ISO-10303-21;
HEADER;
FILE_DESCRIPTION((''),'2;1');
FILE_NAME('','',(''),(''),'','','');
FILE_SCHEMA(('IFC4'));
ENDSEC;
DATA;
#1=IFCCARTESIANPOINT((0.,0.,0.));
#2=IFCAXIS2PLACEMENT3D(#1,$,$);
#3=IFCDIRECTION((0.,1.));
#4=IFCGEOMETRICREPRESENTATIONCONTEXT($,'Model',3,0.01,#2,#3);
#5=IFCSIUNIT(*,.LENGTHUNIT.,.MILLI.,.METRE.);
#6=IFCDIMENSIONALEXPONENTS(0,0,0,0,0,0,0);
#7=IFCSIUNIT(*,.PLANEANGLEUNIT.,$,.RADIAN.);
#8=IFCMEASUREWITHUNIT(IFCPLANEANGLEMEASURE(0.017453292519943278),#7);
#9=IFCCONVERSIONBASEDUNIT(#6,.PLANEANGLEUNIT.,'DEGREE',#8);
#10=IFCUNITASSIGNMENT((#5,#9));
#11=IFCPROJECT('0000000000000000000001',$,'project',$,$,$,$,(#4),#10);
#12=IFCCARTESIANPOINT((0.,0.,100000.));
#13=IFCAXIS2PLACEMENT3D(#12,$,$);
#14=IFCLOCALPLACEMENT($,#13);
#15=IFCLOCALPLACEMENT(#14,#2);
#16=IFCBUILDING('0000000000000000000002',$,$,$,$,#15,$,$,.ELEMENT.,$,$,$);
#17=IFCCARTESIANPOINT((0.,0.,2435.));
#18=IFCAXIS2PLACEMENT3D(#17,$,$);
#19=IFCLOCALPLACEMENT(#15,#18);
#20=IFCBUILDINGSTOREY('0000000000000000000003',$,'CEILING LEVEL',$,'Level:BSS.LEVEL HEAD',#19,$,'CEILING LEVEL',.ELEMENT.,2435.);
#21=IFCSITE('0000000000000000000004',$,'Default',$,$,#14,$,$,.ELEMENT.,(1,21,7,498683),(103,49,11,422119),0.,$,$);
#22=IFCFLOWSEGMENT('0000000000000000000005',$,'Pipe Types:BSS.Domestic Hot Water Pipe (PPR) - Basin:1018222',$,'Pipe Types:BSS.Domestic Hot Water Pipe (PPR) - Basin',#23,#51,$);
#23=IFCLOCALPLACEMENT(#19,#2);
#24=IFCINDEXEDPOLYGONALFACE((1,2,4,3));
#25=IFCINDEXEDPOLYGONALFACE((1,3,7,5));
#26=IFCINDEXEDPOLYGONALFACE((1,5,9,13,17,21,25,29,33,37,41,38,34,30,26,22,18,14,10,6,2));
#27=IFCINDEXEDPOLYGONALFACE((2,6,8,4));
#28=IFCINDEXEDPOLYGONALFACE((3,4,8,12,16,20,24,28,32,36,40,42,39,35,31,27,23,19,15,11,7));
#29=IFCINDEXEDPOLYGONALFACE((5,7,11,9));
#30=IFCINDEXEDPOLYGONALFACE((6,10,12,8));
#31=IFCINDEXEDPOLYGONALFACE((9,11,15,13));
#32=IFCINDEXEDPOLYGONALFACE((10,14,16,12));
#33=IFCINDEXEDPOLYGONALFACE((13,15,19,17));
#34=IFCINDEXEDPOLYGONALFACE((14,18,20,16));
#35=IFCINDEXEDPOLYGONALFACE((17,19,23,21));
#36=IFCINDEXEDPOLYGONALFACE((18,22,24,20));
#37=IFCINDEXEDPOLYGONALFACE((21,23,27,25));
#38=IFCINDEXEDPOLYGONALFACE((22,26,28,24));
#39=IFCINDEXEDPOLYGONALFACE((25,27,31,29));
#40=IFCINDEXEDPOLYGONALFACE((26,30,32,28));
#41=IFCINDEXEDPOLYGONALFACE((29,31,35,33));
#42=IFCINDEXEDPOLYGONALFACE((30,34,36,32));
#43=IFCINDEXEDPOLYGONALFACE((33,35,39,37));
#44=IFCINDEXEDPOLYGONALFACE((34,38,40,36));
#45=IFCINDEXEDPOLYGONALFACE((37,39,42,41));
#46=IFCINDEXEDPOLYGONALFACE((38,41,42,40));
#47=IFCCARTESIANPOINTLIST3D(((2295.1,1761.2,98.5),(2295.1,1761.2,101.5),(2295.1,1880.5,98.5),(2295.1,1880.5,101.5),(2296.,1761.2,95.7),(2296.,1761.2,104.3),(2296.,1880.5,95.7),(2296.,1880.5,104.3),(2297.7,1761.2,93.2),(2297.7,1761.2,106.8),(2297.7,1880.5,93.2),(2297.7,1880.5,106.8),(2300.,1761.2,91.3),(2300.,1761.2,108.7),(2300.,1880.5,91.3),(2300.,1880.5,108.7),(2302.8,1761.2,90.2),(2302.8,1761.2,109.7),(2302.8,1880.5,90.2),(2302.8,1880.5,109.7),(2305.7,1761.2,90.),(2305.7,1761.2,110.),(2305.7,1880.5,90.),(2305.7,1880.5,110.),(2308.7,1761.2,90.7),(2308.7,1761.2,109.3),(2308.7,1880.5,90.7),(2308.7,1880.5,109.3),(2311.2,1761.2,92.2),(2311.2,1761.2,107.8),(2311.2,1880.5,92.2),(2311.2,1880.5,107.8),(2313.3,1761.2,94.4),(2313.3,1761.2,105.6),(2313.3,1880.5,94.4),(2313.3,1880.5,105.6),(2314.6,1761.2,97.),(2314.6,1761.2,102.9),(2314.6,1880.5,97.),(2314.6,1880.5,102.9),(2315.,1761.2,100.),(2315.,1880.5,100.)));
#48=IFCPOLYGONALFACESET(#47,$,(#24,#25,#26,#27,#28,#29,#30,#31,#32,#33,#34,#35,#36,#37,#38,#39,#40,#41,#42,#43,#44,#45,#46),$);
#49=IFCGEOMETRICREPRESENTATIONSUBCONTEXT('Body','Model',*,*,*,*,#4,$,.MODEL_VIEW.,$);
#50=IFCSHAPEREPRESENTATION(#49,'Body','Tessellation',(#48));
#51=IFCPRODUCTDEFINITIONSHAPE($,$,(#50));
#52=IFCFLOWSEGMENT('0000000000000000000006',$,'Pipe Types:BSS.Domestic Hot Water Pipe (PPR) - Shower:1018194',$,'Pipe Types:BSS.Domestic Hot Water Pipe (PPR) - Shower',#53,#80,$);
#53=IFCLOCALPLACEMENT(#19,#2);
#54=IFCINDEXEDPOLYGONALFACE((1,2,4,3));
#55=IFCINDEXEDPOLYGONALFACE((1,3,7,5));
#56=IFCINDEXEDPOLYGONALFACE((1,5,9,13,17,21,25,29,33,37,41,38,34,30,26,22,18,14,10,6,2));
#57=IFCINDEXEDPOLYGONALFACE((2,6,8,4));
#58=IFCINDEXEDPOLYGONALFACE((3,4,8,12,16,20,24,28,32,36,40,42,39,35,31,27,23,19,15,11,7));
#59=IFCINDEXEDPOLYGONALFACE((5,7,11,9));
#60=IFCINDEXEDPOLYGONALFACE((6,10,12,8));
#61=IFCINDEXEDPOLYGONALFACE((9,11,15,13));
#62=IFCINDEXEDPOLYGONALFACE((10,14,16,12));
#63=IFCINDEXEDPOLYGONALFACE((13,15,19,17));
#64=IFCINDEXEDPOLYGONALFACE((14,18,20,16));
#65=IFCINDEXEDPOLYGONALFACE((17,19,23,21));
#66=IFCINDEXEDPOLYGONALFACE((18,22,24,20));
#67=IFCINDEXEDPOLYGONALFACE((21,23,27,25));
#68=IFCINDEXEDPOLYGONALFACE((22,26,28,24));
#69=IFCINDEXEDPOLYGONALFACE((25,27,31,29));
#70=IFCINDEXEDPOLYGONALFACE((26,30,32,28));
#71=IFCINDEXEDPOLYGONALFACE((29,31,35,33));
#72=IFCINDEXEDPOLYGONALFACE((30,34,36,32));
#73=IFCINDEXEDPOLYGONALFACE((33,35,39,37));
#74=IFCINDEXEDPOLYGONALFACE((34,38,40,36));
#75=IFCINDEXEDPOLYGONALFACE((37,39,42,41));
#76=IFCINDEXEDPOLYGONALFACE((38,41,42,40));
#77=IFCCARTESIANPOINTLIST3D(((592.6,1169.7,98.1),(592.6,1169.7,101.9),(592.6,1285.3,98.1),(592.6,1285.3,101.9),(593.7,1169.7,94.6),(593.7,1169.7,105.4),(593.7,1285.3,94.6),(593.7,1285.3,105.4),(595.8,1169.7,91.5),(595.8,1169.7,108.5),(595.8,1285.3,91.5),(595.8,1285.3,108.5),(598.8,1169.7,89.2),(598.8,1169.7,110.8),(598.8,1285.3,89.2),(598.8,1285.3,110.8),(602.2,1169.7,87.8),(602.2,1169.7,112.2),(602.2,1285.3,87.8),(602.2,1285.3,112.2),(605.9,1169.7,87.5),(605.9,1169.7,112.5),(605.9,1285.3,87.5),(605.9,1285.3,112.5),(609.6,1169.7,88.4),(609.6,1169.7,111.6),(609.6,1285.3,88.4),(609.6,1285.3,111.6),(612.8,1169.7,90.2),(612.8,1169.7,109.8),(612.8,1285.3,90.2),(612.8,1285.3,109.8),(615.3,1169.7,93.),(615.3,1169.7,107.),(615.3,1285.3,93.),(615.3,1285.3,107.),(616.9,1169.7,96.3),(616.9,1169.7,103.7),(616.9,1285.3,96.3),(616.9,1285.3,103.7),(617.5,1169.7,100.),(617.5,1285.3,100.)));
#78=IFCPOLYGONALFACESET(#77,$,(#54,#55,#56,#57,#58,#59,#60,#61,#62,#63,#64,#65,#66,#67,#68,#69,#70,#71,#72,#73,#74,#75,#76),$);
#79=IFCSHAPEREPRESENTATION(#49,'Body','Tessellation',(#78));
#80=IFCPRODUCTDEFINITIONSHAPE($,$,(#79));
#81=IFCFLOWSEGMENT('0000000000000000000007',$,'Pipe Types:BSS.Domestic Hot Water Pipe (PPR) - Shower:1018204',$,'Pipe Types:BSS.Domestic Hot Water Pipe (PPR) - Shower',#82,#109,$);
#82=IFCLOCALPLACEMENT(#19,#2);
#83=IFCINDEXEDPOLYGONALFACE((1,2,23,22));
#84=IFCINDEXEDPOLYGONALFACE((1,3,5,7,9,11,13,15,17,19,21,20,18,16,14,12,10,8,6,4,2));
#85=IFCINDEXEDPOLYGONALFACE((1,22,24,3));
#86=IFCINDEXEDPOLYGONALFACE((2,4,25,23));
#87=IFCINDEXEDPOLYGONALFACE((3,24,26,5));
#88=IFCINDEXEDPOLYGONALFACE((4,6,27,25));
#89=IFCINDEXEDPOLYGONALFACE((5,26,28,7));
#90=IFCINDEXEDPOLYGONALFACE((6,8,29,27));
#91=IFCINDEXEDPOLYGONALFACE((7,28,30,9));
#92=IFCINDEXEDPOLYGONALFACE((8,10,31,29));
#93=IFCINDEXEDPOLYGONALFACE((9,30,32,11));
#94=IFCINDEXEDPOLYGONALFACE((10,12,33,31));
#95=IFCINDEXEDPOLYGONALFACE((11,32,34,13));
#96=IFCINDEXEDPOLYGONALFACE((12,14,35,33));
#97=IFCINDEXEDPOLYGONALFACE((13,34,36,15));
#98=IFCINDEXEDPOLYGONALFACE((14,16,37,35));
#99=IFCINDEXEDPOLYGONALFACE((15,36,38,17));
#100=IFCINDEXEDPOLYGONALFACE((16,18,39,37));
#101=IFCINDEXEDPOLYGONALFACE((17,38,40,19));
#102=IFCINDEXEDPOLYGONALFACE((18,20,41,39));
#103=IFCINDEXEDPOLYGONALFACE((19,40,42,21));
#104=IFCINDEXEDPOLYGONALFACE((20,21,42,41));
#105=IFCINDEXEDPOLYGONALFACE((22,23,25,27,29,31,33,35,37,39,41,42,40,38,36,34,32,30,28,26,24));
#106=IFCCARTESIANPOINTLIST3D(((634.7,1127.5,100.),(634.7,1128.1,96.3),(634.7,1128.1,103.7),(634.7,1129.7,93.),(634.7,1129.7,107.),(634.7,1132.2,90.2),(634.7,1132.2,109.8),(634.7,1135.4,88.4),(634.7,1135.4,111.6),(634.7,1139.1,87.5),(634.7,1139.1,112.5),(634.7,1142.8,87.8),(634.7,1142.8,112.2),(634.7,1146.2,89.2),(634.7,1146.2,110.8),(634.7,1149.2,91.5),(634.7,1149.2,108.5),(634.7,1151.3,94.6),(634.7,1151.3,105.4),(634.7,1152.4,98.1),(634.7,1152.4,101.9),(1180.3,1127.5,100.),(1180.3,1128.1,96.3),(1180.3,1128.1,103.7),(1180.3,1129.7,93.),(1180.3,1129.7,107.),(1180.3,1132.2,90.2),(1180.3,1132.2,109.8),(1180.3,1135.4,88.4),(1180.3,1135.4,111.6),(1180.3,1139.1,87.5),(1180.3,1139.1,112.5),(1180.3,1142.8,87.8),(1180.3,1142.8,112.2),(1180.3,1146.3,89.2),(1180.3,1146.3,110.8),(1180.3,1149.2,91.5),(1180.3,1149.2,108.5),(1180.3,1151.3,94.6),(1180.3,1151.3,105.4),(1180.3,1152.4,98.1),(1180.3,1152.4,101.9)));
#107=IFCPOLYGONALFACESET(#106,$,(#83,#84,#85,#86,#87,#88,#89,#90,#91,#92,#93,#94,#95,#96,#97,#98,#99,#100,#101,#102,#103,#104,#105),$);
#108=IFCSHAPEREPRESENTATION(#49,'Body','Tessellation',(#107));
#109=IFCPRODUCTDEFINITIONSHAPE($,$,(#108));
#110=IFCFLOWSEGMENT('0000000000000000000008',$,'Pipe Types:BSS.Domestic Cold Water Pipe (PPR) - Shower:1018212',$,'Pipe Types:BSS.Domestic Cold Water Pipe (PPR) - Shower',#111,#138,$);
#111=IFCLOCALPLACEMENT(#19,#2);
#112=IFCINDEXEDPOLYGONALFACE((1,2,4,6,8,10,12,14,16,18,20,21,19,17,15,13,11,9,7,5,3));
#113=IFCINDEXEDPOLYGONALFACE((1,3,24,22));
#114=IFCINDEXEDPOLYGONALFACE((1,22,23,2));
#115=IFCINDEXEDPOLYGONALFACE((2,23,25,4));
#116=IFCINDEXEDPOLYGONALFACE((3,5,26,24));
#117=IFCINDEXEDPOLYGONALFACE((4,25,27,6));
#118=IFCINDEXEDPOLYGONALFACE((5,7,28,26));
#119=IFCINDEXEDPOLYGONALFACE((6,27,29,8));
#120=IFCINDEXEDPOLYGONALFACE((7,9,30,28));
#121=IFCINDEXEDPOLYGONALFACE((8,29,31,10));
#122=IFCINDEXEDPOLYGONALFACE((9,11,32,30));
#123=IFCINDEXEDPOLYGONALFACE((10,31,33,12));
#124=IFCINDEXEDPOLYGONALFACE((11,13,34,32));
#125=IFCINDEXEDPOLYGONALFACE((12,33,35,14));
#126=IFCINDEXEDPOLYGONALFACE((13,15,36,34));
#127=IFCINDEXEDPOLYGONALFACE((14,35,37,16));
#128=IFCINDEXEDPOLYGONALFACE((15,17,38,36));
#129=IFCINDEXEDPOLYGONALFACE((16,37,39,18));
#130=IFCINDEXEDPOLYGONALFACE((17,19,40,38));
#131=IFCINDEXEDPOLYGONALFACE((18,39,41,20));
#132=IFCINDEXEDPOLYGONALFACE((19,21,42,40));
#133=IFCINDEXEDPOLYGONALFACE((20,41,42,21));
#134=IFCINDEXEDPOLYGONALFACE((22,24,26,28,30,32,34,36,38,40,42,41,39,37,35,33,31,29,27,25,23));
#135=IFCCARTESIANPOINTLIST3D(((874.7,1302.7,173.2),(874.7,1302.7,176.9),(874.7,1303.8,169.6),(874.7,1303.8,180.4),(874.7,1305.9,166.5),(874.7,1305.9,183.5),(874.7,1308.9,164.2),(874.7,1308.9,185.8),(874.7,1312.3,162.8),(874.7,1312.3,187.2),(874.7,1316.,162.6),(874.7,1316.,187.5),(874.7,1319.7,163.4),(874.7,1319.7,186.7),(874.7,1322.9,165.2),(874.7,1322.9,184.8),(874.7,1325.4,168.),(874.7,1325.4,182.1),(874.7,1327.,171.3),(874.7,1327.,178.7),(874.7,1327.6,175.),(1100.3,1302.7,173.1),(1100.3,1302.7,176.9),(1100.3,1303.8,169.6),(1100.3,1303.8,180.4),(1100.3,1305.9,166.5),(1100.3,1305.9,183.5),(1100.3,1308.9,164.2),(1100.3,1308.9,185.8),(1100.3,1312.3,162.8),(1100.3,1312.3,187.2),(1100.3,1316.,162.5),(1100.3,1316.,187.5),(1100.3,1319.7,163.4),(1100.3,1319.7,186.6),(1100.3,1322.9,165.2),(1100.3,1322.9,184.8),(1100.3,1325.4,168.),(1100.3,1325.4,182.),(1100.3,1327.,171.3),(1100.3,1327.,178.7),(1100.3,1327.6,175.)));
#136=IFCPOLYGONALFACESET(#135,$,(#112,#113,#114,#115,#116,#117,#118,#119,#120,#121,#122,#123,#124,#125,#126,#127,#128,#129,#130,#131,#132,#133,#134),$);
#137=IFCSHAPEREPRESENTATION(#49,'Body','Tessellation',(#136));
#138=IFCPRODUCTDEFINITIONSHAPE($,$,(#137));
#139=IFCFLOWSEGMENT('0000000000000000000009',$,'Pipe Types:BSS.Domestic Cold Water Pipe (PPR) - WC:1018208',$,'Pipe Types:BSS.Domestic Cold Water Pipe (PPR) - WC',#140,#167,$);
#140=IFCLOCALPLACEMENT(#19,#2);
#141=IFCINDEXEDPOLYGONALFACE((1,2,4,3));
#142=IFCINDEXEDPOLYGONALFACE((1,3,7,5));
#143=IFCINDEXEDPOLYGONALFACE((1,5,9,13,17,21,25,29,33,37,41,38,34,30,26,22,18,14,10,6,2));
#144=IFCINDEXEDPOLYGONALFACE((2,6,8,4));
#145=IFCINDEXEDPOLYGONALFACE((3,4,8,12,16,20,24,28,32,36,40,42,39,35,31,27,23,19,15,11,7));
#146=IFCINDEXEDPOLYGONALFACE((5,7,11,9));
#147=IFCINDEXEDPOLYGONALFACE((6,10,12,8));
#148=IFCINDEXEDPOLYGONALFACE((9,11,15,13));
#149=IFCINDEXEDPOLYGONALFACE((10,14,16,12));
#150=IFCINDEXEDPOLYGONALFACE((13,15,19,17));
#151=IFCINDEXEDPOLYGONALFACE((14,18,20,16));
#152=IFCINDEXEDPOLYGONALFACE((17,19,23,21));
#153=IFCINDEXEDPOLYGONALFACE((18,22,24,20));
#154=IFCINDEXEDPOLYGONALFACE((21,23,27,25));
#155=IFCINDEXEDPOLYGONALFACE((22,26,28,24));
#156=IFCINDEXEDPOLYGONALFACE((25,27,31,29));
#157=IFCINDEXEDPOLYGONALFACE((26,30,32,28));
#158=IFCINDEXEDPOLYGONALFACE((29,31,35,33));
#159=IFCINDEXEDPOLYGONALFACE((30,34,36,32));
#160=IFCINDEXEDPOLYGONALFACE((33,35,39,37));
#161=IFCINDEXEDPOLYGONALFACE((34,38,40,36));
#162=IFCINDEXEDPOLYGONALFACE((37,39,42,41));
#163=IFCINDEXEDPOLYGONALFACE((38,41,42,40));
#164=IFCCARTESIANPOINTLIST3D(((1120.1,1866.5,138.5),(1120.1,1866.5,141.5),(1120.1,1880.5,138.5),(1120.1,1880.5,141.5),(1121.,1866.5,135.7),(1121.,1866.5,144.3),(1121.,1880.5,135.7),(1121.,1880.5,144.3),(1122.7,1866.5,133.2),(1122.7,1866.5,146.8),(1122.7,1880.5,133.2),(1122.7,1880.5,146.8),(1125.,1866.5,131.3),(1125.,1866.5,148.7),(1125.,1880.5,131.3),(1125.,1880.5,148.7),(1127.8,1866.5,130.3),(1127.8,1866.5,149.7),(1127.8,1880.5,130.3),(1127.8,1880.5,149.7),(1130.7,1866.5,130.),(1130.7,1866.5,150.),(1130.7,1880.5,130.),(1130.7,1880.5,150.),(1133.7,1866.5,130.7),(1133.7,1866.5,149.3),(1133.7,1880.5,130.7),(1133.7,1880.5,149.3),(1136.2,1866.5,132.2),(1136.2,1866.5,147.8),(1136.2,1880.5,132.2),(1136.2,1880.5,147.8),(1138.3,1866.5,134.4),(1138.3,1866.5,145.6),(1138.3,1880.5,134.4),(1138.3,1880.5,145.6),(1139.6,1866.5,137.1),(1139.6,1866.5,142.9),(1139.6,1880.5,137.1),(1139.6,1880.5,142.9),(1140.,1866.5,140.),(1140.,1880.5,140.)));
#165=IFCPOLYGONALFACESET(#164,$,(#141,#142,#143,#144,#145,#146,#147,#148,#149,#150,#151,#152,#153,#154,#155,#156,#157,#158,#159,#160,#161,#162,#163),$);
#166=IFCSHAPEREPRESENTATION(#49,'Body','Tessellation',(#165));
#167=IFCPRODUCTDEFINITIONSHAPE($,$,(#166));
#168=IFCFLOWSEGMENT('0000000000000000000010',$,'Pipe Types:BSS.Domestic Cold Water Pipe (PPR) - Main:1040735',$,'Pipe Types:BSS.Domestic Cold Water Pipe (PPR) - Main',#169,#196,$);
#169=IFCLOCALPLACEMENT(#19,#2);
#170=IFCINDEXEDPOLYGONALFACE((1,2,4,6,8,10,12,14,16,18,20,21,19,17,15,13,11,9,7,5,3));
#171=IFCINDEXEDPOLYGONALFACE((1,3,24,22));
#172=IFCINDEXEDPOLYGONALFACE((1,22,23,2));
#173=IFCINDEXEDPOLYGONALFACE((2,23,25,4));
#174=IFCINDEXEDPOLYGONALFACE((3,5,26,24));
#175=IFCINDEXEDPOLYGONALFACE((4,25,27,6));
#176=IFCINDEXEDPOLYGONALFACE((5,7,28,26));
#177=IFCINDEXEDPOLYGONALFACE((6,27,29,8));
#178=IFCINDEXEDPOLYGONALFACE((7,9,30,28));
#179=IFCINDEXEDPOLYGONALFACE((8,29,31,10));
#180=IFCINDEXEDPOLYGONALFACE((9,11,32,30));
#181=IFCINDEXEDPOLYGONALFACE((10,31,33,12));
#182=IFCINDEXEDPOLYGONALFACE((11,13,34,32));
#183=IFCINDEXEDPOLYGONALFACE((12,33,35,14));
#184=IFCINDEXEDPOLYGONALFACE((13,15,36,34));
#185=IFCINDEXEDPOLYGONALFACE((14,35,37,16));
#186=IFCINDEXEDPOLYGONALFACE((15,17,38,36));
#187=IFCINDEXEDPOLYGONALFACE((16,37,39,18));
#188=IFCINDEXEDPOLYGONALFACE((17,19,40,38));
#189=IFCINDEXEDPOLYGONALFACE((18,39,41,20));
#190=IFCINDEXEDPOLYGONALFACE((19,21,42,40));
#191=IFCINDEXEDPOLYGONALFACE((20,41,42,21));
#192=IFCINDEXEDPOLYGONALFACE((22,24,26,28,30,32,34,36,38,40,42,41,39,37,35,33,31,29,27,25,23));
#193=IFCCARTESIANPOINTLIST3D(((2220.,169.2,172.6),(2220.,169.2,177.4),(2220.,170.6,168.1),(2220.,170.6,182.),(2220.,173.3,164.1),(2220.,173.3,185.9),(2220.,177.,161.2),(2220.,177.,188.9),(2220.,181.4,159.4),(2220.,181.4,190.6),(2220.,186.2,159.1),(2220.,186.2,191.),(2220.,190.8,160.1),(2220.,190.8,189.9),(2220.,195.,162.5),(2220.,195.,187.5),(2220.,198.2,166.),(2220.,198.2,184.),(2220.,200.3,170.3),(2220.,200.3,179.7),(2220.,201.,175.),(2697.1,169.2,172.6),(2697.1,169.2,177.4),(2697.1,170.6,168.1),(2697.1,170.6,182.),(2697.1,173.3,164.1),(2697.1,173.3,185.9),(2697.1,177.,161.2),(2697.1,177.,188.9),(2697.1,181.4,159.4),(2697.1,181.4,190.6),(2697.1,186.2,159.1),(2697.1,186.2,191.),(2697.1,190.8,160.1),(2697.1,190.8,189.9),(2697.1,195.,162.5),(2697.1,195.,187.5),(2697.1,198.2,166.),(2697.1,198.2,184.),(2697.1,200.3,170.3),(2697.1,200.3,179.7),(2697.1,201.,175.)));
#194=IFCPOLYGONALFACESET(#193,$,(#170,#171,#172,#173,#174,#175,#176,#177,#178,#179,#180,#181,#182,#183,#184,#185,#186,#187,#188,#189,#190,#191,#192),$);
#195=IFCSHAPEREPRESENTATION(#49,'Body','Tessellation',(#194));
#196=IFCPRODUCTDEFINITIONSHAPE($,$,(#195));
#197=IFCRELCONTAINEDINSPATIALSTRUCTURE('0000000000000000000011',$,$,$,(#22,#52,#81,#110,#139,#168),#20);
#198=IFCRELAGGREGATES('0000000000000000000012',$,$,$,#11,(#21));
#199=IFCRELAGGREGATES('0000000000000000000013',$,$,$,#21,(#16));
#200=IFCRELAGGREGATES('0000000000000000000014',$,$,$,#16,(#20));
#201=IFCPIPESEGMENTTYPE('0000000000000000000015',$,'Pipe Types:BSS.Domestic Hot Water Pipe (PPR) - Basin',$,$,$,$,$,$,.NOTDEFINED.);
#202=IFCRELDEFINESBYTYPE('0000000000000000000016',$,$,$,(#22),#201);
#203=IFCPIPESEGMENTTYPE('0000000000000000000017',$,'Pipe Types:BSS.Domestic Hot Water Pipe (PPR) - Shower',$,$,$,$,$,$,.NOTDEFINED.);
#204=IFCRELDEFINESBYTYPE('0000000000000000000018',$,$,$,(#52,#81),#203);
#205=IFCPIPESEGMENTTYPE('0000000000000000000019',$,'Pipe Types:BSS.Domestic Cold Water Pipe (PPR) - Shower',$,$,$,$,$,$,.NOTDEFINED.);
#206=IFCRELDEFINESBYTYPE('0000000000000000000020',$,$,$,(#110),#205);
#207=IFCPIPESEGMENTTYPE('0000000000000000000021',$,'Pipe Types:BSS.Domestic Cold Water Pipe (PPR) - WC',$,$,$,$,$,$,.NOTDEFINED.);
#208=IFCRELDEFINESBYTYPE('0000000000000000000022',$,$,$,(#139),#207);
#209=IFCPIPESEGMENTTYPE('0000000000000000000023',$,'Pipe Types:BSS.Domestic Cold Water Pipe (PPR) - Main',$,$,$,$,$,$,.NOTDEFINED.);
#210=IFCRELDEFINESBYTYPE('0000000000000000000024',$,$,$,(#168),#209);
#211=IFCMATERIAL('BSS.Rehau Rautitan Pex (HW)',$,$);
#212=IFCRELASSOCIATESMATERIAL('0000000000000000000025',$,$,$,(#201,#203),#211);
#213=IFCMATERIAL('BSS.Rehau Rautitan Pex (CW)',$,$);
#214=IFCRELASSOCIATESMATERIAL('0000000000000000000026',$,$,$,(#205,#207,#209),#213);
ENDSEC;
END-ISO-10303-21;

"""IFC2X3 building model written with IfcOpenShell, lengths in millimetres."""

from ifc_helpers import new_model, entity, si_unit, converted_unit, direction, frame, frame_2d, origin, origin_2d_with_axis, place, context, subcontext, project, spatial, circle, extrude, material, type_object, element, save


model = new_model("IFC2X3")

# Units and contexts
model_context = context("Model", 3, precision=0.01, world=origin(), true_north=direction((0.0, 1.0)))
body_context = subcontext(model_context, "Body", "Model", "MODEL_VIEW")
ifc_project = project(units=[si_unit("LENGTHUNIT", "METRE", prefix="MILLI"), converted_unit("PLANEANGLEUNIT", "DEGREE", entity("IfcPlaneAngleMeasure", 0.017453292519943278), si_unit("PLANEANGLEUNIT", "RADIAN"), dimensions=[0, 0, 0, 0, 0, 0, 0])], contexts=[model_context])

# Site, building, storey
site_placement = place(None, frame((0.0, 0.0, 100000.0)))
site = spatial("IfcSite", under=ifc_project, at=site_placement, Name="Default", CompositionType="ELEMENT", RefLatitude=(1, 21, 7, 498683), RefLongitude=(103, 49, 11, 422119), RefElevation=0.0)
building_placement = place(site_placement, origin())
building = spatial("IfcBuilding", under=site, at=building_placement, CompositionType="ELEMENT")
storey_placement = place(building_placement, frame((0.0, 0.0, 2435.0)))
storey = spatial("IfcBuildingStorey", under=building, at=storey_placement, Name="CEILING LEVEL", ObjectType="Level:BSS.LEVEL HEAD", LongName="CEILING LEVEL", CompositionType="ELEMENT", Elevation=2435.0)

# Flow segments
ifc_material_1 = material(Name="BSS.Rehau Rautitan Pex (HW)")
pipe_segment_type_1 = type_object("IfcPipeSegmentType", Name="Pipe Types:BSS.Domestic Hot Water Pipe (PPR) - Basin", PredefinedType="NOTDEFINED", material=ifc_material_1)
flow_segment_1_placement = place(storey_placement, origin())
element("IfcFlowSegment", 1, at=flow_segment_1_placement, inside=storey, type_object=pipe_segment_type_1, Name="Pipe Types:BSS.Domestic Hot Water Pipe (PPR) - Basin:1018222", ObjectType="Pipe Types:BSS.Domestic Hot Water Pipe (PPR) - Basin", context=body_context, shape_type="SweptSolid", body=[
    extrude(circle(Radius=10.0, at=frame_2d((0.0, 0.0), x_axis=(1.0, 0.0))), frame((2305.0, 1880.5, 100.0), z_axis=(0.00001, -1.0, 0.0), x_axis=(1.0, 0.00001, 0.0)), (0.0, 0.0, 1.0), 119.3),
])
pipe_segment_type_2 = type_object("IfcPipeSegmentType", Name="Pipe Types:BSS.Domestic Hot Water Pipe (PPR) - Shower", PredefinedType="NOTDEFINED", material=ifc_material_1)
flow_segment_2_placement = place(storey_placement, origin())
element("IfcFlowSegment", 2, at=flow_segment_2_placement, inside=storey, type_object=pipe_segment_type_2, Name="Pipe Types:BSS.Domestic Hot Water Pipe (PPR) - Shower:1018194", ObjectType="Pipe Types:BSS.Domestic Hot Water Pipe (PPR) - Shower", context=body_context, shape_type="SweptSolid", body=[
    extrude(circle(Radius=12.5, at=frame_2d((0.0, 0.0), x_axis=(1.0, 0.0))), frame((605.0, 1285.3, 100.0), z_axis=(0.0, -1.0, 0.000036), x_axis=(1.0, 0.0, 0.0)), (0.0, 0.0, 1.0), 115.6),
])
flow_segment_3_placement = place(storey_placement, origin())
element("IfcFlowSegment", 3, at=flow_segment_3_placement, inside=storey, type_object=pipe_segment_type_2, Name="Pipe Types:BSS.Domestic Hot Water Pipe (PPR) - Shower:1018204", ObjectType="Pipe Types:BSS.Domestic Hot Water Pipe (PPR) - Shower", context=body_context, shape_type="SweptSolid", body=[
    extrude(circle(Radius=12.5, at=frame_2d((0.0, 0.0), x_axis=(1.0, 0.0))), frame((634.7, 1140.0, 100.0), z_axis=(1.0, 0.0, -0.00001), x_axis=(0.0, -1.0, 0.0)), (0.0, 0.0, 1.0), 545.6),
])
ifc_material_2 = material(Name="BSS.Rehau Rautitan Pex (CW)")
pipe_segment_type_3 = type_object("IfcPipeSegmentType", Name="Pipe Types:BSS.Domestic Cold Water Pipe (PPR) - Shower", PredefinedType="NOTDEFINED", material=ifc_material_2)
flow_segment_4_placement = place(storey_placement, origin())
element("IfcFlowSegment", 4, at=flow_segment_4_placement, inside=storey, type_object=pipe_segment_type_3, Name="Pipe Types:BSS.Domestic Cold Water Pipe (PPR) - Shower:1018212", ObjectType="Pipe Types:BSS.Domestic Cold Water Pipe (PPR) - Shower", context=body_context, shape_type="SweptSolid", body=[
    extrude(circle(Radius=12.5, at=origin_2d_with_axis()), frame((874.7, 1315.1, 175.0), z_axis=(1.0, 0.000003, -0.000078), x_axis=(-0.000003, 1.0, 0.0)), (0.0, 0.0, 1.0), 225.6),
])
pipe_segment_type_4 = type_object("IfcPipeSegmentType", Name="Pipe Types:BSS.Domestic Cold Water Pipe (PPR) - WC", PredefinedType="NOTDEFINED", material=ifc_material_2)
flow_segment_5_placement = place(storey_placement, origin())
element("IfcFlowSegment", 5, at=flow_segment_5_placement, inside=storey, type_object=pipe_segment_type_4, Name="Pipe Types:BSS.Domestic Cold Water Pipe (PPR) - WC:1018208", ObjectType="Pipe Types:BSS.Domestic Cold Water Pipe (PPR) - WC", context=body_context, shape_type="SweptSolid", body=[
    extrude(circle(Radius=10.0, at=frame_2d((0.0, 0.0), x_axis=(1.0, 0.0))), frame((1130.0, 1866.5, 140.0), z_axis=(-0.000042, 1.0, 0.0), x_axis=(1.0, 0.000042, 0.0)), (0.0, 0.0, 1.0), 14.0),
])
pipe_segment_type_5 = type_object("IfcPipeSegmentType", Name="Pipe Types:BSS.Domestic Cold Water Pipe (PPR) - Main", PredefinedType="NOTDEFINED", material=ifc_material_2)
flow_segment_6_placement = place(storey_placement, origin())
element("IfcFlowSegment", 6, at=flow_segment_6_placement, inside=storey, type_object=pipe_segment_type_5, Name="Pipe Types:BSS.Domestic Cold Water Pipe (PPR) - Main:1040735", ObjectType="Pipe Types:BSS.Domestic Cold Water Pipe (PPR) - Main", context=body_context, shape_type="SweptSolid", body=[
    extrude(circle(Radius=16.0, at=origin_2d_with_axis()), frame((2220.0, 185.0, 175.0), z_axis=(1.0, 0.0, 0.0), x_axis=(0.0, 1.0, 0.0)), (0.0, 0.0, 1.0), 477.1),
])

save(model, "model.ifc")
